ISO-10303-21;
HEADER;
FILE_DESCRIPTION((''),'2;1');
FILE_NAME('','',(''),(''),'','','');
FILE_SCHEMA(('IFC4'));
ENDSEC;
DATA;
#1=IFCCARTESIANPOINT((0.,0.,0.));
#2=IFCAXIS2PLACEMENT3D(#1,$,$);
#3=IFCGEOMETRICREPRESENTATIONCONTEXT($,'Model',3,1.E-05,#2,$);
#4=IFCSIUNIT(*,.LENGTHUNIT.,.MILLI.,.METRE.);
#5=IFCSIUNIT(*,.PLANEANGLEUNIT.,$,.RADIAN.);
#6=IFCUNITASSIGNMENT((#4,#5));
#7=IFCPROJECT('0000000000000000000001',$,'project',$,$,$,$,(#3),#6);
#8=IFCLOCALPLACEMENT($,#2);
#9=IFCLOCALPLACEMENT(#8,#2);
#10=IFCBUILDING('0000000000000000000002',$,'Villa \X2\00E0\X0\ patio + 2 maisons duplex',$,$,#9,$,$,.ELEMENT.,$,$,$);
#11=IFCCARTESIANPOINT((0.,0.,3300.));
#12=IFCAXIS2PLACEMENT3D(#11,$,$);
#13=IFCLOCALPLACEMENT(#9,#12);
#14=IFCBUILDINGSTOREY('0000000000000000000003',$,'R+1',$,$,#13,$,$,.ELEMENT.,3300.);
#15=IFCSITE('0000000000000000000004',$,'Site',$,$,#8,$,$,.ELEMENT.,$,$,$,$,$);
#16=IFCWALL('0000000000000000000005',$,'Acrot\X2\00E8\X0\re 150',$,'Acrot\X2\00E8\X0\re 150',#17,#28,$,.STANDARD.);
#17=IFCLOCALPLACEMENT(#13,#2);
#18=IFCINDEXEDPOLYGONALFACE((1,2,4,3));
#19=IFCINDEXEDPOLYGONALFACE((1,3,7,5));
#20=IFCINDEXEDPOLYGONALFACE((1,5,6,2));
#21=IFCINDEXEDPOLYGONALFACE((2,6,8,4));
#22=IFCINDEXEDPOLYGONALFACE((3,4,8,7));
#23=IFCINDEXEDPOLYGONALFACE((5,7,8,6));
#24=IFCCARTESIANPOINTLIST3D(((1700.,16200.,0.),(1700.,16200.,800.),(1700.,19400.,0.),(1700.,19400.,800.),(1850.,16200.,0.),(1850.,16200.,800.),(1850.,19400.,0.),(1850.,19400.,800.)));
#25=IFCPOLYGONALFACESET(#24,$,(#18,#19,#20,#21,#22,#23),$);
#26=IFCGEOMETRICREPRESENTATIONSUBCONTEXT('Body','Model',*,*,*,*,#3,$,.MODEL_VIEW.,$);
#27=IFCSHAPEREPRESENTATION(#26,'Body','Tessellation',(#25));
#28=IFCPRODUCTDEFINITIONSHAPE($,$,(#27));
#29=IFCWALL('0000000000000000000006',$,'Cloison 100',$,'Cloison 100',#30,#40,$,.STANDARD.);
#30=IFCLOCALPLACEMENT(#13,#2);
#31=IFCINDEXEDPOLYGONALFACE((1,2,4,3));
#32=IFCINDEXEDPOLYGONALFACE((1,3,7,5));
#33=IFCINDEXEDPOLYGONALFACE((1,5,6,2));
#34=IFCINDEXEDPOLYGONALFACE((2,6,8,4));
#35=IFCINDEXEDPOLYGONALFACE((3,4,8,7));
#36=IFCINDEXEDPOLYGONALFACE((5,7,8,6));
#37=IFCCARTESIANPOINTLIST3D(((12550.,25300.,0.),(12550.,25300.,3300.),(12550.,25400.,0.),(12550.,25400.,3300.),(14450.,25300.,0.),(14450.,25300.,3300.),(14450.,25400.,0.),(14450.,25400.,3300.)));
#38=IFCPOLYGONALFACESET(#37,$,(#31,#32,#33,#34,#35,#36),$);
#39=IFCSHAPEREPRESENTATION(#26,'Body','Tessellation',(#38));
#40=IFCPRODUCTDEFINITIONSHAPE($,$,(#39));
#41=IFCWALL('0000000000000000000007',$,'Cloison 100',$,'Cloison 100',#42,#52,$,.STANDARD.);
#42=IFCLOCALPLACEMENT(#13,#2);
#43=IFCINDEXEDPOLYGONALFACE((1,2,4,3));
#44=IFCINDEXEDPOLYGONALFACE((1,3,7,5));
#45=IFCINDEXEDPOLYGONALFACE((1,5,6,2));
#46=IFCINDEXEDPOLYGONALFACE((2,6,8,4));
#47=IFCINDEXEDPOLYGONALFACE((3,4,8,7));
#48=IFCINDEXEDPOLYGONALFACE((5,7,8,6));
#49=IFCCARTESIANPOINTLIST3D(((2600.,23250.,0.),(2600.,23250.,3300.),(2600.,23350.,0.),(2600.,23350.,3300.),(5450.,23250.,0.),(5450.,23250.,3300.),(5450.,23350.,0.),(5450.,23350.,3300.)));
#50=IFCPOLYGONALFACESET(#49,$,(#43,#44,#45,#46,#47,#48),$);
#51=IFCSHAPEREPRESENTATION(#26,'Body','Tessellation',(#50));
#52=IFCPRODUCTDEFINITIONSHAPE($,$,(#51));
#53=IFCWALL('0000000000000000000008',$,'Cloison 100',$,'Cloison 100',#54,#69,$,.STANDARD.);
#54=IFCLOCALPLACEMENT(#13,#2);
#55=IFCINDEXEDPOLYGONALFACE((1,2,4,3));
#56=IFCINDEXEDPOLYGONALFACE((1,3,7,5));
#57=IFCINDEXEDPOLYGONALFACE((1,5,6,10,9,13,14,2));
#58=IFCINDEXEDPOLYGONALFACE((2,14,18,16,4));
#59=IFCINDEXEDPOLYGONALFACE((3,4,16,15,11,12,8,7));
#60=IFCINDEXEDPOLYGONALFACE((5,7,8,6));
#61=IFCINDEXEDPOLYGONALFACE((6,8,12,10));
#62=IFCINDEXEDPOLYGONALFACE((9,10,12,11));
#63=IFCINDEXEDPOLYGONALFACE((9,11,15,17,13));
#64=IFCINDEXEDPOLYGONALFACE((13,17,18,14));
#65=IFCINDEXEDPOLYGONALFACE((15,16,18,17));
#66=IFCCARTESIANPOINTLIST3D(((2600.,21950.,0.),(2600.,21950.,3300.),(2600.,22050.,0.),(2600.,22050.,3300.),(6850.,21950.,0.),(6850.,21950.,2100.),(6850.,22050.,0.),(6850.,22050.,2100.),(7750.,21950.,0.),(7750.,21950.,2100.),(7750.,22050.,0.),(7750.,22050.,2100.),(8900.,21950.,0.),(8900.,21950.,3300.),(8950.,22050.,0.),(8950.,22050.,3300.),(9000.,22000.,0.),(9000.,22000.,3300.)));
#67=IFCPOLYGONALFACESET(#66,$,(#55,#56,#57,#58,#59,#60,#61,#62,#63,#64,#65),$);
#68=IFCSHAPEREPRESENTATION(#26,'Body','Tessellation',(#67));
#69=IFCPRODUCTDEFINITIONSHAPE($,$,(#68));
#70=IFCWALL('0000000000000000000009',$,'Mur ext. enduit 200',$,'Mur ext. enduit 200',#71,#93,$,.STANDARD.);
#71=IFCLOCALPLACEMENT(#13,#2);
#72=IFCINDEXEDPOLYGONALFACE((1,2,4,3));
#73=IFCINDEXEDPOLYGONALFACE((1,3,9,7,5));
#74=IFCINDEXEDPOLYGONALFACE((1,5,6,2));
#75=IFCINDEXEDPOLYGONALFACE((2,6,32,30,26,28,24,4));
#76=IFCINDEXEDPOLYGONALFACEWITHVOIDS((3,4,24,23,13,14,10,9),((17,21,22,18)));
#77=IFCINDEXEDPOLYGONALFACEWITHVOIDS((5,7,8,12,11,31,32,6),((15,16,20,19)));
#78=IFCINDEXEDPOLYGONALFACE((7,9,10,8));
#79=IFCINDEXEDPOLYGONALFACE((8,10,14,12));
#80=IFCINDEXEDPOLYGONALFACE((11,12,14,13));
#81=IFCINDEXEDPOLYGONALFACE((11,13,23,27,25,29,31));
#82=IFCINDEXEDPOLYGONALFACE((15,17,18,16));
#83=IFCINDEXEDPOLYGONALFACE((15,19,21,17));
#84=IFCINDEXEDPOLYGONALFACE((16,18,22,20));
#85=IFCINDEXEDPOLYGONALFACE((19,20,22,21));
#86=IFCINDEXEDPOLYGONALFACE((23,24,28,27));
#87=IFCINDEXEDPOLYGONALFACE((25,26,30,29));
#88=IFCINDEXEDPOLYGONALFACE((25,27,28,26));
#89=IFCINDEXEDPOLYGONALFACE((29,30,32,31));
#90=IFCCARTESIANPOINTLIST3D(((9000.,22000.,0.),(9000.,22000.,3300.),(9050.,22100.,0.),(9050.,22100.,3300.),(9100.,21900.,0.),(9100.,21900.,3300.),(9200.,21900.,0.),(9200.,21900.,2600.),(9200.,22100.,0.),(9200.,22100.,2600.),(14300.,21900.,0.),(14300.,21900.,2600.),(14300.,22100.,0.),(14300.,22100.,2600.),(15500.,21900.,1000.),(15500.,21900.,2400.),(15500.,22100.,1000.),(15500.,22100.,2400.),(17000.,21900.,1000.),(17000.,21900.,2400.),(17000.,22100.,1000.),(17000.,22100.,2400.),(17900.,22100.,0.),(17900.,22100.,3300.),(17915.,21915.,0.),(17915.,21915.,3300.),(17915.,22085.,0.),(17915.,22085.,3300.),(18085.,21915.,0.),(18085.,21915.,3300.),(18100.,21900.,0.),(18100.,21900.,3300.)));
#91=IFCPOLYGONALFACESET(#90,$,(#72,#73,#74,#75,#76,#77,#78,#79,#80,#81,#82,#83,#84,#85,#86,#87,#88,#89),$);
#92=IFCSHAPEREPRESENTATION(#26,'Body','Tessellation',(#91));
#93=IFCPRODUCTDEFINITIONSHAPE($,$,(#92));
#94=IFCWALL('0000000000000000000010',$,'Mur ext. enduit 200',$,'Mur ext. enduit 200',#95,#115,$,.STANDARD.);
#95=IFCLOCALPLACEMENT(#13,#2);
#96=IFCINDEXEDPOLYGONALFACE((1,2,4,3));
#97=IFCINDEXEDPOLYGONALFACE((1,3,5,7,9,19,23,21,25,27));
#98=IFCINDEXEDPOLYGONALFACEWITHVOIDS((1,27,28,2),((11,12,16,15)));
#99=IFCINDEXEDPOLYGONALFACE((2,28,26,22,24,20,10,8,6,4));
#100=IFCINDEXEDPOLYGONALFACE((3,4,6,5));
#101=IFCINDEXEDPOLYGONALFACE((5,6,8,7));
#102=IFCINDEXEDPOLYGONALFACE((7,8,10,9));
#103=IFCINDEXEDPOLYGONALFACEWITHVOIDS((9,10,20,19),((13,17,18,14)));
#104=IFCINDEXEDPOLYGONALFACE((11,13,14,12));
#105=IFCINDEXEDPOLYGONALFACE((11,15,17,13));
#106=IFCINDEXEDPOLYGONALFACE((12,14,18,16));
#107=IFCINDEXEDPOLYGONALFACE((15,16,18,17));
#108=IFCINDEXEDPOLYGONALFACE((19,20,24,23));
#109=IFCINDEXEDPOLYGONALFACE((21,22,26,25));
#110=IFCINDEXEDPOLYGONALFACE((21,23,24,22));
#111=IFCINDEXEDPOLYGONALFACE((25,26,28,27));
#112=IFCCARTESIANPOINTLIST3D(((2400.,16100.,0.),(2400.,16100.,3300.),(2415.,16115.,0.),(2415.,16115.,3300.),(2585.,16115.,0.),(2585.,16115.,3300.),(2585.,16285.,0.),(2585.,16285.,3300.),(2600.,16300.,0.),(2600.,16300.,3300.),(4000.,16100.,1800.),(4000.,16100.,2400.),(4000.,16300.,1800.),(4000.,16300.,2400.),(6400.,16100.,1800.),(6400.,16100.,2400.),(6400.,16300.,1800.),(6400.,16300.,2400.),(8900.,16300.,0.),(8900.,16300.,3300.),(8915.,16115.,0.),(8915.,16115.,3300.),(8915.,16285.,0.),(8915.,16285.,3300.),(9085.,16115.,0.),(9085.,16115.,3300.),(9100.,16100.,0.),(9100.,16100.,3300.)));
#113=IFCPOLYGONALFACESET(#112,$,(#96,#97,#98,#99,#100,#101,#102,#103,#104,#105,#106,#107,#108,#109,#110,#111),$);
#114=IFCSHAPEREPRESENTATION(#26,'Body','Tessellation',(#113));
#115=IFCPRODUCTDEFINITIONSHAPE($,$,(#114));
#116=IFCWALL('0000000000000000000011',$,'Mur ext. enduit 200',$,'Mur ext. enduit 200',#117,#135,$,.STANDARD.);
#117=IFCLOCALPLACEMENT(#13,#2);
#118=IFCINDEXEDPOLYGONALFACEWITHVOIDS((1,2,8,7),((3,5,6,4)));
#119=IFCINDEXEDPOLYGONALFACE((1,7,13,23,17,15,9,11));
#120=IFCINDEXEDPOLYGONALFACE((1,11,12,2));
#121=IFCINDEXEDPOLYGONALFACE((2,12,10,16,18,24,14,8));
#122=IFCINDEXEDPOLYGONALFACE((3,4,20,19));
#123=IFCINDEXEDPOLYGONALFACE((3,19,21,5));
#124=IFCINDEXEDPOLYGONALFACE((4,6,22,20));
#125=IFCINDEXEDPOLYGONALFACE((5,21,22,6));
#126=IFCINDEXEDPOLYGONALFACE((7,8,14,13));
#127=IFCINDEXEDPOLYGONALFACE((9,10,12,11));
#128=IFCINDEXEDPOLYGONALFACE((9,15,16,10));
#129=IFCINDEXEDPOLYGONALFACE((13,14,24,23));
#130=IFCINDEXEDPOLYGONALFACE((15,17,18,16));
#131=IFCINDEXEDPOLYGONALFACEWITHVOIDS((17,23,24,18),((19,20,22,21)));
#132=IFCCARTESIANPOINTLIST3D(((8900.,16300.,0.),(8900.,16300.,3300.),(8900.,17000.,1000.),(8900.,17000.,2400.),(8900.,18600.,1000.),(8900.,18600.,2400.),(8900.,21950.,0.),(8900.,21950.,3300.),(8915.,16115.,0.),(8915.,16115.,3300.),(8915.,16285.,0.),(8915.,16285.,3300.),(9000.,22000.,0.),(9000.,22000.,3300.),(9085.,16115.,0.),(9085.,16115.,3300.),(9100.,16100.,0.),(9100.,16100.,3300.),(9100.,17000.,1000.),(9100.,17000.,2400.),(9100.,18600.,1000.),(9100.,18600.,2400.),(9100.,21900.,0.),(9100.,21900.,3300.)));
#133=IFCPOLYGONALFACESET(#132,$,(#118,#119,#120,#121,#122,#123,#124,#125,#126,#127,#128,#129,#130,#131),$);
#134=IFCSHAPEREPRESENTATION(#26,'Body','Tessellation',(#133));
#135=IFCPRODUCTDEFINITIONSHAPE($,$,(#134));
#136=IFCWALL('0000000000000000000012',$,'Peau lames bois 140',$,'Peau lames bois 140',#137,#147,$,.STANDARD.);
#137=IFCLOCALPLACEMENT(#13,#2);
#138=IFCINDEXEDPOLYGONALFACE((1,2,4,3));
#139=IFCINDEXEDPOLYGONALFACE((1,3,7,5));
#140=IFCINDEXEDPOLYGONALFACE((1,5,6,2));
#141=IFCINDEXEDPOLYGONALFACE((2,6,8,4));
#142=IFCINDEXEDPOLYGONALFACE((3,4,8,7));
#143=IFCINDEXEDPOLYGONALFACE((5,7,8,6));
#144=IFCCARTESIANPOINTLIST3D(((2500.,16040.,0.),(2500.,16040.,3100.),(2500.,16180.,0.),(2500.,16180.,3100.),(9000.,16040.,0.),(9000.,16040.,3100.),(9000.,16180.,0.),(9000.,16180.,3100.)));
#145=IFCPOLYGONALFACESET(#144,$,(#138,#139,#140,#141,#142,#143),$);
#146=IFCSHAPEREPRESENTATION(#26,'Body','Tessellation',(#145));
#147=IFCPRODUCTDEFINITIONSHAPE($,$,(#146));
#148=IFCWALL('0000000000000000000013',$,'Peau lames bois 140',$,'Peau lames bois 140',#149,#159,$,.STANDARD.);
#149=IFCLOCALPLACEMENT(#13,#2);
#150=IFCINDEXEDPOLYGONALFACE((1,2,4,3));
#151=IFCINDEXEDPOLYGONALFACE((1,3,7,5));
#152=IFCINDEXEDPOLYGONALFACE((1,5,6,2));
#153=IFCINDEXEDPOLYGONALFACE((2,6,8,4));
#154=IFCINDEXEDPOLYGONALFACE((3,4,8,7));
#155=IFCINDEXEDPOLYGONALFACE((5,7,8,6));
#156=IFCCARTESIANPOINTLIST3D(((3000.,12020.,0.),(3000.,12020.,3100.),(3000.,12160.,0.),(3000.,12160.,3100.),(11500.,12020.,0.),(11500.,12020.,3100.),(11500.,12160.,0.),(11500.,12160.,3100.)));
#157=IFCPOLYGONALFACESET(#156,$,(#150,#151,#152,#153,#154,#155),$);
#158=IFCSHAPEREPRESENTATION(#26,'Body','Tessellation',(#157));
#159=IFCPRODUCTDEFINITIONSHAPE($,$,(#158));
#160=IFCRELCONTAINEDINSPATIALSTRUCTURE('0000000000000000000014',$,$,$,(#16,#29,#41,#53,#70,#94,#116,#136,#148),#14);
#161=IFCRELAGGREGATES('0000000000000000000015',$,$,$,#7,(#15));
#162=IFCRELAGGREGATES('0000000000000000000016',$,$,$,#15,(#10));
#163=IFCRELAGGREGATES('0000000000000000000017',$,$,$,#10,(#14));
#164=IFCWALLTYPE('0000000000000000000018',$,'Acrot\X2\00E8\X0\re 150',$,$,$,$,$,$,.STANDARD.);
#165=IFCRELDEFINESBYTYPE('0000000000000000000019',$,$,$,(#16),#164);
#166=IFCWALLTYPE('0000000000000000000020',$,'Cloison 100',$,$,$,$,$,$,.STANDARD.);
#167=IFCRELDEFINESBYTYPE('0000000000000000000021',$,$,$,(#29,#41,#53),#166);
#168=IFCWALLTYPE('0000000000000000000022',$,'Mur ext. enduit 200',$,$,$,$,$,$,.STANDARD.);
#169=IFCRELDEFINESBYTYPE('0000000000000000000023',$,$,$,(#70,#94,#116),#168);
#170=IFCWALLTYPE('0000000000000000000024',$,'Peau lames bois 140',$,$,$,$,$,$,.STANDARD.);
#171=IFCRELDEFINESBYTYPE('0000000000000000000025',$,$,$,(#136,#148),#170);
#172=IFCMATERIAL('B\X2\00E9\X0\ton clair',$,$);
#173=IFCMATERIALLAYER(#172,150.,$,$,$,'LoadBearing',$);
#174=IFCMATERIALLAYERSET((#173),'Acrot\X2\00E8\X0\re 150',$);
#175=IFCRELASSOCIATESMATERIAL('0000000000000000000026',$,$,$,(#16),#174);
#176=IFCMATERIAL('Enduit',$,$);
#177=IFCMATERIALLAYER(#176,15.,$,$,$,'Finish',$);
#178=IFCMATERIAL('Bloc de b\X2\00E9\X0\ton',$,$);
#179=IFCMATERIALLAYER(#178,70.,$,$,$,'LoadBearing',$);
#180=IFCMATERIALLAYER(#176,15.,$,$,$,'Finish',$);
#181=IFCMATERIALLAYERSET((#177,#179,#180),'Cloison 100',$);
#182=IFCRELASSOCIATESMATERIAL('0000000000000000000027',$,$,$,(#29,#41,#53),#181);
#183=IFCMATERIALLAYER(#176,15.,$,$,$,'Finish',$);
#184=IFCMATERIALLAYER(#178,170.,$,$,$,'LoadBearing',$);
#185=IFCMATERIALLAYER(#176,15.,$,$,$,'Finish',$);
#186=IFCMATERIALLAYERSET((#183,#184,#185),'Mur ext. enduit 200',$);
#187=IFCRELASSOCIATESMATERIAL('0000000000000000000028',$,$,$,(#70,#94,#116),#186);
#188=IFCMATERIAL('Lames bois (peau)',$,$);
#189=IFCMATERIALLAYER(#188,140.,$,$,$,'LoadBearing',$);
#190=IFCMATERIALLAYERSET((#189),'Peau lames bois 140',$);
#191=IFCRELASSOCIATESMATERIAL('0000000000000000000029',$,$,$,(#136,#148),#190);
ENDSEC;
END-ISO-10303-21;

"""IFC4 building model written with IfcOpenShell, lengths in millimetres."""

from ifc_helpers import new_model, si_unit, frame, frame_2d, origin, place, context, subcontext, project, spatial, polyline, rectangle, outline, extrude, material, layer, layer_set, layer_usage, type_object, element, save


model = new_model("IFC4")

# Units and contexts
model_context = context("Model", 3, precision=1e-05, world=origin())
body_context = subcontext(model_context, "Body", "Model", "MODEL_VIEW")
ifc_project = project(units=[si_unit("LENGTHUNIT", "METRE", prefix="MILLI"), si_unit("PLANEANGLEUNIT", "RADIAN")], contexts=[model_context])

# Site, building, storey
site_placement = place(None, origin())
site = spatial("IfcSite", under=ifc_project, at=site_placement, Name="Site", CompositionType="ELEMENT")
building_placement = place(site_placement, origin())
building = spatial("IfcBuilding", under=site, at=building_placement, Name="Villa à patio + 2 maisons duplex", CompositionType="ELEMENT")
storey_placement = place(building_placement, frame((0.0, 0.0, 3300.0)))
storey = spatial("IfcBuildingStorey", under=building, at=storey_placement, Name="R+1", CompositionType="ELEMENT", Elevation=3300.0)

# Walls
ifc_material_1 = material(Name="Béton clair")
ifc_layer_1 = layer(ifc_material_1, 150.0, Category="LoadBearing")
ifc_layer_set_1 = layer_set([ifc_layer_1], Name="Acrotère 150")
ifc_layer_usage_1 = layer_usage(ifc_layer_set_1, "AXIS2", "NEGATIVE", 75.0)
wall_type_1 = type_object("IfcWallType", Name="Acrotère 150", PredefinedType="STANDARD")
wall_1_placement = place(storey_placement, frame((1775.0, 19400.0, 0.0), z_axis=(0.0, 0.0, 1.0), x_axis=(0.0, -1.0, 0.0)))
element("IfcWall", 1, at=wall_1_placement, inside=storey, type_object=wall_type_1, material=ifc_layer_usage_1, Name="Acrotère 150", ObjectType="Acrotère 150", PredefinedType="STANDARD", context=body_context, shape_type="SweptSolid", body=[
    extrude(outline(polyline([(0.0, -75.0), (0.0, 75.0), (3200.0, 75.0), (3200.0, -75.0), (0.0, -75.0)])), origin(), (0.0, 0.0, 1.0), 800.0),
])
ifc_material_2 = material(Name="Enduit")
ifc_layer_2 = layer(ifc_material_2, 15.0, Category="Finish")
ifc_material_3 = material(Name="Bloc de béton")
ifc_layer_3 = layer(ifc_material_3, 70.0, Category="LoadBearing")
ifc_layer_4 = layer(ifc_material_2, 15.0, Category="Finish")
ifc_layer_set_2 = layer_set([ifc_layer_2, ifc_layer_3, ifc_layer_4], Name="Cloison 100")
ifc_layer_usage_2 = layer_usage(ifc_layer_set_2, "AXIS2", "NEGATIVE", 50.0)
wall_type_2 = type_object("IfcWallType", Name="Cloison 100", PredefinedType="STANDARD")
wall_2_placement = place(storey_placement, frame((12500.0, 25350.0, 0.0), z_axis=(0.0, 0.0, 1.0), x_axis=(1.0, 0.0, 0.0)))
element("IfcWall", 2, at=wall_2_placement, inside=storey, type_object=wall_type_2, material=ifc_layer_usage_2, Name="Cloison 100", ObjectType="Cloison 100", PredefinedType="STANDARD", context=body_context, shape_type="SweptSolid", body=[
    extrude(outline(polyline([(50.0, -50.0), (50.0, 50.0), (1950.0, 50.0), (1950.0, -50.0), (50.0, -50.0)])), origin(), (0.0, 0.0, 1.0), 3300.0),
])
wall_3_placement = place(storey_placement, frame((2500.0, 23300.0, 0.0), z_axis=(0.0, 0.0, 1.0), x_axis=(1.0, 0.0, 0.0)))
element("IfcWall", 3, at=wall_3_placement, inside=storey, type_object=wall_type_2, material=ifc_layer_usage_2, Name="Cloison 100", ObjectType="Cloison 100", PredefinedType="STANDARD", context=body_context, shape_type="SweptSolid", body=[
    extrude(outline(polyline([(100.0, -50.0), (100.0, 50.0), (2950.0, 50.0), (2950.0, -50.0), (100.0, -50.0)])), origin(), (0.0, 0.0, 1.0), 3300.0),
])

# Wall, opening
wall_4_placement = place(storey_placement, frame((2500.0, 22000.0, 0.0), z_axis=(0.0, 0.0, 1.0), x_axis=(1.0, 0.0, 0.0)))
wall_4 = element("IfcWall", 4, at=wall_4_placement, inside=storey, type_object=wall_type_2, material=ifc_layer_usage_2, Name="Cloison 100", ObjectType="Cloison 100", PredefinedType="STANDARD", context=body_context, shape_type="SweptSolid", body=[
    extrude(outline(polyline([(100.0, -50.0), (100.0, 50.0), (6450.0, 50.0), (6500.0, 0.0), (6400.0, -50.0), (100.0, -50.0)])), origin(), (0.0, 0.0, 1.0), 3300.0),
])
opening_1_placement = place(wall_4_placement, frame((4350.0, 0.0, 0.0), z_axis=(0.0, 0.0, 1.0), x_axis=(1.0, 0.0, 0.0)))
element("IfcOpeningElement", 5, at=opening_1_placement, cuts=wall_4, PredefinedType="OPENING", context=body_context, shape_type="SweptSolid", body=[
    extrude(rectangle(XDim=900.0, YDim=120.0, at=frame_2d((450.0, 0.0))), origin(), (0.0, 0.0, 1.0), 2100.0),
])

# Wall, openings
ifc_layer_5 = layer(ifc_material_2, 15.0, Category="Finish")
ifc_layer_6 = layer(ifc_material_3, 170.0, Category="LoadBearing")
ifc_layer_7 = layer(ifc_material_2, 15.0, Category="Finish")
ifc_layer_set_3 = layer_set([ifc_layer_5, ifc_layer_6, ifc_layer_7], Name="Mur ext. enduit 200")
ifc_layer_usage_3 = layer_usage(ifc_layer_set_3, "AXIS2", "NEGATIVE", 100.0)
wall_type_3 = type_object("IfcWallType", Name="Mur ext. enduit 200", PredefinedType="STANDARD")
wall_5_placement = place(storey_placement, frame((9000.0, 22000.0, 0.0), z_axis=(0.0, 0.0, 1.0), x_axis=(1.0, 0.0, 0.0)))
wall_5 = element("IfcWall", 6, at=wall_5_placement, inside=storey, type_object=wall_type_3, material=ifc_layer_usage_3, Name="Mur ext. enduit 200", ObjectType="Mur ext. enduit 200", PredefinedType="STANDARD", context=body_context, shape_type="SweptSolid", body=[
    extrude(outline(polyline([(100.0, -100.0), (0.0, 0.0), (50.0, 100.0), (8900.0, 100.0), (8915.0, 85.0), (8915.0, -85.0), (9085.0, -85.0), (9100.0, -100.0), (100.0, -100.0)])), origin(), (0.0, 0.0, 1.0), 3300.0),
])
opening_2_placement = place(wall_5_placement, frame((200.0, 0.0, 0.0), z_axis=(0.0, 0.0, 1.0), x_axis=(1.0, 0.0, 0.0)))
element("IfcOpeningElement", 7, at=opening_2_placement, cuts=wall_5, PredefinedType="OPENING", context=body_context, shape_type="SweptSolid", body=[
    extrude(rectangle(XDim=5100.0, YDim=220.0, at=frame_2d((2550.0, 0.0))), origin(), (0.0, 0.0, 1.0), 2600.0),
])
opening_3_placement = place(wall_5_placement, frame((6500.0, 0.0, 1000.0), z_axis=(0.0, 0.0, 1.0), x_axis=(1.0, 0.0, 0.0)))
element("IfcOpeningElement", 8, at=opening_3_placement, cuts=wall_5, PredefinedType="OPENING", context=body_context, shape_type="SweptSolid", body=[
    extrude(rectangle(XDim=1500.0, YDim=220.0, at=frame_2d((750.0, 0.0))), origin(), (0.0, 0.0, 1.0), 1400.0),
])

# Walls, openings
wall_6_placement = place(storey_placement, frame((2500.0, 16200.0, 0.0), z_axis=(0.0, 0.0, 1.0), x_axis=(1.0, 0.0, 0.0)))
wall_6 = element("IfcWall", 9, at=wall_6_placement, inside=storey, type_object=wall_type_3, material=ifc_layer_usage_3, Name="Mur ext. enduit 200", ObjectType="Mur ext. enduit 200", PredefinedType="STANDARD", context=body_context, shape_type="SweptSolid", body=[
    extrude(outline(polyline([(-100.0, -100.0), (-85.0, -85.0), (85.0, -85.0), (85.0, 85.0), (100.0, 100.0), (6400.0, 100.0), (6415.0, 85.0), (6415.0, -85.0), (6585.0, -85.0), (6600.0, -100.0), (-100.0, -100.0)])), origin(), (0.0, 0.0, 1.0), 3300.0),
])
opening_4_placement = place(wall_6_placement, frame((1500.0, 0.0, 1800.0), z_axis=(0.0, 0.0, 1.0), x_axis=(1.0, 0.0, 0.0)))
element("IfcOpeningElement", 10, at=opening_4_placement, cuts=wall_6, PredefinedType="OPENING", context=body_context, shape_type="SweptSolid", body=[
    extrude(rectangle(XDim=2400.0, YDim=220.0, at=frame_2d((1200.0, 0.0))), origin(), (0.0, 0.0, 1.0), 600.0),
])
wall_7_placement = place(storey_placement, frame((9000.0, 22000.0, 0.0), z_axis=(0.0, 0.0, 1.0), x_axis=(0.0, -1.0, 0.0)))
wall_7 = element("IfcWall", 11, at=wall_7_placement, inside=storey, type_object=wall_type_3, material=ifc_layer_usage_3, Name="Mur ext. enduit 200", ObjectType="Mur ext. enduit 200", PredefinedType="STANDARD", context=body_context, shape_type="SweptSolid", body=[
    extrude(outline(polyline([(50.0, -100.0), (0.0, 0.0), (100.0, 100.0), (5900.0, 100.0), (5885.0, 85.0), (5885.0, -85.0), (5715.0, -85.0), (5700.0, -100.0), (50.0, -100.0)])), origin(), (0.0, 0.0, 1.0), 3300.0),
])
opening_5_placement = place(wall_7_placement, frame((3400.0, 0.0, 1000.0), z_axis=(0.0, 0.0, 1.0), x_axis=(1.0, 0.0, 0.0)))
element("IfcOpeningElement", 12, at=opening_5_placement, cuts=wall_7, PredefinedType="OPENING", context=body_context, shape_type="SweptSolid", body=[
    extrude(rectangle(XDim=1600.0, YDim=220.0, at=frame_2d((800.0, 0.0))), origin(), (0.0, 0.0, 1.0), 1400.0),
])

# Walls
ifc_material_4 = material(Name="Lames bois (peau)")
ifc_layer_8 = layer(ifc_material_4, 140.0, Category="LoadBearing")
ifc_layer_set_4 = layer_set([ifc_layer_8], Name="Peau lames bois 140")
ifc_layer_usage_4 = layer_usage(ifc_layer_set_4, "AXIS2", "NEGATIVE", 70.0)
wall_type_4 = type_object("IfcWallType", Name="Peau lames bois 140", PredefinedType="STANDARD")
wall_8_placement = place(storey_placement, frame((2500.0, 16110.0, 0.0), z_axis=(0.0, 0.0, 1.0), x_axis=(1.0, 0.0, 0.0)))
element("IfcWall", 13, at=wall_8_placement, inside=storey, type_object=wall_type_4, material=ifc_layer_usage_4, Name="Peau lames bois 140", ObjectType="Peau lames bois 140", PredefinedType="STANDARD", context=body_context, shape_type="SweptSolid", body=[
    extrude(outline(polyline([(0.0, -70.0), (0.0, 70.0), (6500.0, 70.0), (6500.0, -70.0), (0.0, -70.0)])), origin(), (0.0, 0.0, 1.0), 3100.0),
])
wall_9_placement = place(storey_placement, frame((3000.0, 12090.0, 0.0), z_axis=(0.0, 0.0, 1.0), x_axis=(1.0, 0.0, 0.0)))
element("IfcWall", 14, at=wall_9_placement, inside=storey, type_object=wall_type_4, material=ifc_layer_usage_4, Name="Peau lames bois 140", ObjectType="Peau lames bois 140", PredefinedType="STANDARD", context=body_context, shape_type="SweptSolid", body=[
    extrude(outline(polyline([(0.0, -70.0), (0.0, 70.0), (8500.0, 70.0), (8500.0, -70.0), (0.0, -70.0)])), origin(), (0.0, 0.0, 1.0), 3100.0),
])

save(model, "model.ifc")
